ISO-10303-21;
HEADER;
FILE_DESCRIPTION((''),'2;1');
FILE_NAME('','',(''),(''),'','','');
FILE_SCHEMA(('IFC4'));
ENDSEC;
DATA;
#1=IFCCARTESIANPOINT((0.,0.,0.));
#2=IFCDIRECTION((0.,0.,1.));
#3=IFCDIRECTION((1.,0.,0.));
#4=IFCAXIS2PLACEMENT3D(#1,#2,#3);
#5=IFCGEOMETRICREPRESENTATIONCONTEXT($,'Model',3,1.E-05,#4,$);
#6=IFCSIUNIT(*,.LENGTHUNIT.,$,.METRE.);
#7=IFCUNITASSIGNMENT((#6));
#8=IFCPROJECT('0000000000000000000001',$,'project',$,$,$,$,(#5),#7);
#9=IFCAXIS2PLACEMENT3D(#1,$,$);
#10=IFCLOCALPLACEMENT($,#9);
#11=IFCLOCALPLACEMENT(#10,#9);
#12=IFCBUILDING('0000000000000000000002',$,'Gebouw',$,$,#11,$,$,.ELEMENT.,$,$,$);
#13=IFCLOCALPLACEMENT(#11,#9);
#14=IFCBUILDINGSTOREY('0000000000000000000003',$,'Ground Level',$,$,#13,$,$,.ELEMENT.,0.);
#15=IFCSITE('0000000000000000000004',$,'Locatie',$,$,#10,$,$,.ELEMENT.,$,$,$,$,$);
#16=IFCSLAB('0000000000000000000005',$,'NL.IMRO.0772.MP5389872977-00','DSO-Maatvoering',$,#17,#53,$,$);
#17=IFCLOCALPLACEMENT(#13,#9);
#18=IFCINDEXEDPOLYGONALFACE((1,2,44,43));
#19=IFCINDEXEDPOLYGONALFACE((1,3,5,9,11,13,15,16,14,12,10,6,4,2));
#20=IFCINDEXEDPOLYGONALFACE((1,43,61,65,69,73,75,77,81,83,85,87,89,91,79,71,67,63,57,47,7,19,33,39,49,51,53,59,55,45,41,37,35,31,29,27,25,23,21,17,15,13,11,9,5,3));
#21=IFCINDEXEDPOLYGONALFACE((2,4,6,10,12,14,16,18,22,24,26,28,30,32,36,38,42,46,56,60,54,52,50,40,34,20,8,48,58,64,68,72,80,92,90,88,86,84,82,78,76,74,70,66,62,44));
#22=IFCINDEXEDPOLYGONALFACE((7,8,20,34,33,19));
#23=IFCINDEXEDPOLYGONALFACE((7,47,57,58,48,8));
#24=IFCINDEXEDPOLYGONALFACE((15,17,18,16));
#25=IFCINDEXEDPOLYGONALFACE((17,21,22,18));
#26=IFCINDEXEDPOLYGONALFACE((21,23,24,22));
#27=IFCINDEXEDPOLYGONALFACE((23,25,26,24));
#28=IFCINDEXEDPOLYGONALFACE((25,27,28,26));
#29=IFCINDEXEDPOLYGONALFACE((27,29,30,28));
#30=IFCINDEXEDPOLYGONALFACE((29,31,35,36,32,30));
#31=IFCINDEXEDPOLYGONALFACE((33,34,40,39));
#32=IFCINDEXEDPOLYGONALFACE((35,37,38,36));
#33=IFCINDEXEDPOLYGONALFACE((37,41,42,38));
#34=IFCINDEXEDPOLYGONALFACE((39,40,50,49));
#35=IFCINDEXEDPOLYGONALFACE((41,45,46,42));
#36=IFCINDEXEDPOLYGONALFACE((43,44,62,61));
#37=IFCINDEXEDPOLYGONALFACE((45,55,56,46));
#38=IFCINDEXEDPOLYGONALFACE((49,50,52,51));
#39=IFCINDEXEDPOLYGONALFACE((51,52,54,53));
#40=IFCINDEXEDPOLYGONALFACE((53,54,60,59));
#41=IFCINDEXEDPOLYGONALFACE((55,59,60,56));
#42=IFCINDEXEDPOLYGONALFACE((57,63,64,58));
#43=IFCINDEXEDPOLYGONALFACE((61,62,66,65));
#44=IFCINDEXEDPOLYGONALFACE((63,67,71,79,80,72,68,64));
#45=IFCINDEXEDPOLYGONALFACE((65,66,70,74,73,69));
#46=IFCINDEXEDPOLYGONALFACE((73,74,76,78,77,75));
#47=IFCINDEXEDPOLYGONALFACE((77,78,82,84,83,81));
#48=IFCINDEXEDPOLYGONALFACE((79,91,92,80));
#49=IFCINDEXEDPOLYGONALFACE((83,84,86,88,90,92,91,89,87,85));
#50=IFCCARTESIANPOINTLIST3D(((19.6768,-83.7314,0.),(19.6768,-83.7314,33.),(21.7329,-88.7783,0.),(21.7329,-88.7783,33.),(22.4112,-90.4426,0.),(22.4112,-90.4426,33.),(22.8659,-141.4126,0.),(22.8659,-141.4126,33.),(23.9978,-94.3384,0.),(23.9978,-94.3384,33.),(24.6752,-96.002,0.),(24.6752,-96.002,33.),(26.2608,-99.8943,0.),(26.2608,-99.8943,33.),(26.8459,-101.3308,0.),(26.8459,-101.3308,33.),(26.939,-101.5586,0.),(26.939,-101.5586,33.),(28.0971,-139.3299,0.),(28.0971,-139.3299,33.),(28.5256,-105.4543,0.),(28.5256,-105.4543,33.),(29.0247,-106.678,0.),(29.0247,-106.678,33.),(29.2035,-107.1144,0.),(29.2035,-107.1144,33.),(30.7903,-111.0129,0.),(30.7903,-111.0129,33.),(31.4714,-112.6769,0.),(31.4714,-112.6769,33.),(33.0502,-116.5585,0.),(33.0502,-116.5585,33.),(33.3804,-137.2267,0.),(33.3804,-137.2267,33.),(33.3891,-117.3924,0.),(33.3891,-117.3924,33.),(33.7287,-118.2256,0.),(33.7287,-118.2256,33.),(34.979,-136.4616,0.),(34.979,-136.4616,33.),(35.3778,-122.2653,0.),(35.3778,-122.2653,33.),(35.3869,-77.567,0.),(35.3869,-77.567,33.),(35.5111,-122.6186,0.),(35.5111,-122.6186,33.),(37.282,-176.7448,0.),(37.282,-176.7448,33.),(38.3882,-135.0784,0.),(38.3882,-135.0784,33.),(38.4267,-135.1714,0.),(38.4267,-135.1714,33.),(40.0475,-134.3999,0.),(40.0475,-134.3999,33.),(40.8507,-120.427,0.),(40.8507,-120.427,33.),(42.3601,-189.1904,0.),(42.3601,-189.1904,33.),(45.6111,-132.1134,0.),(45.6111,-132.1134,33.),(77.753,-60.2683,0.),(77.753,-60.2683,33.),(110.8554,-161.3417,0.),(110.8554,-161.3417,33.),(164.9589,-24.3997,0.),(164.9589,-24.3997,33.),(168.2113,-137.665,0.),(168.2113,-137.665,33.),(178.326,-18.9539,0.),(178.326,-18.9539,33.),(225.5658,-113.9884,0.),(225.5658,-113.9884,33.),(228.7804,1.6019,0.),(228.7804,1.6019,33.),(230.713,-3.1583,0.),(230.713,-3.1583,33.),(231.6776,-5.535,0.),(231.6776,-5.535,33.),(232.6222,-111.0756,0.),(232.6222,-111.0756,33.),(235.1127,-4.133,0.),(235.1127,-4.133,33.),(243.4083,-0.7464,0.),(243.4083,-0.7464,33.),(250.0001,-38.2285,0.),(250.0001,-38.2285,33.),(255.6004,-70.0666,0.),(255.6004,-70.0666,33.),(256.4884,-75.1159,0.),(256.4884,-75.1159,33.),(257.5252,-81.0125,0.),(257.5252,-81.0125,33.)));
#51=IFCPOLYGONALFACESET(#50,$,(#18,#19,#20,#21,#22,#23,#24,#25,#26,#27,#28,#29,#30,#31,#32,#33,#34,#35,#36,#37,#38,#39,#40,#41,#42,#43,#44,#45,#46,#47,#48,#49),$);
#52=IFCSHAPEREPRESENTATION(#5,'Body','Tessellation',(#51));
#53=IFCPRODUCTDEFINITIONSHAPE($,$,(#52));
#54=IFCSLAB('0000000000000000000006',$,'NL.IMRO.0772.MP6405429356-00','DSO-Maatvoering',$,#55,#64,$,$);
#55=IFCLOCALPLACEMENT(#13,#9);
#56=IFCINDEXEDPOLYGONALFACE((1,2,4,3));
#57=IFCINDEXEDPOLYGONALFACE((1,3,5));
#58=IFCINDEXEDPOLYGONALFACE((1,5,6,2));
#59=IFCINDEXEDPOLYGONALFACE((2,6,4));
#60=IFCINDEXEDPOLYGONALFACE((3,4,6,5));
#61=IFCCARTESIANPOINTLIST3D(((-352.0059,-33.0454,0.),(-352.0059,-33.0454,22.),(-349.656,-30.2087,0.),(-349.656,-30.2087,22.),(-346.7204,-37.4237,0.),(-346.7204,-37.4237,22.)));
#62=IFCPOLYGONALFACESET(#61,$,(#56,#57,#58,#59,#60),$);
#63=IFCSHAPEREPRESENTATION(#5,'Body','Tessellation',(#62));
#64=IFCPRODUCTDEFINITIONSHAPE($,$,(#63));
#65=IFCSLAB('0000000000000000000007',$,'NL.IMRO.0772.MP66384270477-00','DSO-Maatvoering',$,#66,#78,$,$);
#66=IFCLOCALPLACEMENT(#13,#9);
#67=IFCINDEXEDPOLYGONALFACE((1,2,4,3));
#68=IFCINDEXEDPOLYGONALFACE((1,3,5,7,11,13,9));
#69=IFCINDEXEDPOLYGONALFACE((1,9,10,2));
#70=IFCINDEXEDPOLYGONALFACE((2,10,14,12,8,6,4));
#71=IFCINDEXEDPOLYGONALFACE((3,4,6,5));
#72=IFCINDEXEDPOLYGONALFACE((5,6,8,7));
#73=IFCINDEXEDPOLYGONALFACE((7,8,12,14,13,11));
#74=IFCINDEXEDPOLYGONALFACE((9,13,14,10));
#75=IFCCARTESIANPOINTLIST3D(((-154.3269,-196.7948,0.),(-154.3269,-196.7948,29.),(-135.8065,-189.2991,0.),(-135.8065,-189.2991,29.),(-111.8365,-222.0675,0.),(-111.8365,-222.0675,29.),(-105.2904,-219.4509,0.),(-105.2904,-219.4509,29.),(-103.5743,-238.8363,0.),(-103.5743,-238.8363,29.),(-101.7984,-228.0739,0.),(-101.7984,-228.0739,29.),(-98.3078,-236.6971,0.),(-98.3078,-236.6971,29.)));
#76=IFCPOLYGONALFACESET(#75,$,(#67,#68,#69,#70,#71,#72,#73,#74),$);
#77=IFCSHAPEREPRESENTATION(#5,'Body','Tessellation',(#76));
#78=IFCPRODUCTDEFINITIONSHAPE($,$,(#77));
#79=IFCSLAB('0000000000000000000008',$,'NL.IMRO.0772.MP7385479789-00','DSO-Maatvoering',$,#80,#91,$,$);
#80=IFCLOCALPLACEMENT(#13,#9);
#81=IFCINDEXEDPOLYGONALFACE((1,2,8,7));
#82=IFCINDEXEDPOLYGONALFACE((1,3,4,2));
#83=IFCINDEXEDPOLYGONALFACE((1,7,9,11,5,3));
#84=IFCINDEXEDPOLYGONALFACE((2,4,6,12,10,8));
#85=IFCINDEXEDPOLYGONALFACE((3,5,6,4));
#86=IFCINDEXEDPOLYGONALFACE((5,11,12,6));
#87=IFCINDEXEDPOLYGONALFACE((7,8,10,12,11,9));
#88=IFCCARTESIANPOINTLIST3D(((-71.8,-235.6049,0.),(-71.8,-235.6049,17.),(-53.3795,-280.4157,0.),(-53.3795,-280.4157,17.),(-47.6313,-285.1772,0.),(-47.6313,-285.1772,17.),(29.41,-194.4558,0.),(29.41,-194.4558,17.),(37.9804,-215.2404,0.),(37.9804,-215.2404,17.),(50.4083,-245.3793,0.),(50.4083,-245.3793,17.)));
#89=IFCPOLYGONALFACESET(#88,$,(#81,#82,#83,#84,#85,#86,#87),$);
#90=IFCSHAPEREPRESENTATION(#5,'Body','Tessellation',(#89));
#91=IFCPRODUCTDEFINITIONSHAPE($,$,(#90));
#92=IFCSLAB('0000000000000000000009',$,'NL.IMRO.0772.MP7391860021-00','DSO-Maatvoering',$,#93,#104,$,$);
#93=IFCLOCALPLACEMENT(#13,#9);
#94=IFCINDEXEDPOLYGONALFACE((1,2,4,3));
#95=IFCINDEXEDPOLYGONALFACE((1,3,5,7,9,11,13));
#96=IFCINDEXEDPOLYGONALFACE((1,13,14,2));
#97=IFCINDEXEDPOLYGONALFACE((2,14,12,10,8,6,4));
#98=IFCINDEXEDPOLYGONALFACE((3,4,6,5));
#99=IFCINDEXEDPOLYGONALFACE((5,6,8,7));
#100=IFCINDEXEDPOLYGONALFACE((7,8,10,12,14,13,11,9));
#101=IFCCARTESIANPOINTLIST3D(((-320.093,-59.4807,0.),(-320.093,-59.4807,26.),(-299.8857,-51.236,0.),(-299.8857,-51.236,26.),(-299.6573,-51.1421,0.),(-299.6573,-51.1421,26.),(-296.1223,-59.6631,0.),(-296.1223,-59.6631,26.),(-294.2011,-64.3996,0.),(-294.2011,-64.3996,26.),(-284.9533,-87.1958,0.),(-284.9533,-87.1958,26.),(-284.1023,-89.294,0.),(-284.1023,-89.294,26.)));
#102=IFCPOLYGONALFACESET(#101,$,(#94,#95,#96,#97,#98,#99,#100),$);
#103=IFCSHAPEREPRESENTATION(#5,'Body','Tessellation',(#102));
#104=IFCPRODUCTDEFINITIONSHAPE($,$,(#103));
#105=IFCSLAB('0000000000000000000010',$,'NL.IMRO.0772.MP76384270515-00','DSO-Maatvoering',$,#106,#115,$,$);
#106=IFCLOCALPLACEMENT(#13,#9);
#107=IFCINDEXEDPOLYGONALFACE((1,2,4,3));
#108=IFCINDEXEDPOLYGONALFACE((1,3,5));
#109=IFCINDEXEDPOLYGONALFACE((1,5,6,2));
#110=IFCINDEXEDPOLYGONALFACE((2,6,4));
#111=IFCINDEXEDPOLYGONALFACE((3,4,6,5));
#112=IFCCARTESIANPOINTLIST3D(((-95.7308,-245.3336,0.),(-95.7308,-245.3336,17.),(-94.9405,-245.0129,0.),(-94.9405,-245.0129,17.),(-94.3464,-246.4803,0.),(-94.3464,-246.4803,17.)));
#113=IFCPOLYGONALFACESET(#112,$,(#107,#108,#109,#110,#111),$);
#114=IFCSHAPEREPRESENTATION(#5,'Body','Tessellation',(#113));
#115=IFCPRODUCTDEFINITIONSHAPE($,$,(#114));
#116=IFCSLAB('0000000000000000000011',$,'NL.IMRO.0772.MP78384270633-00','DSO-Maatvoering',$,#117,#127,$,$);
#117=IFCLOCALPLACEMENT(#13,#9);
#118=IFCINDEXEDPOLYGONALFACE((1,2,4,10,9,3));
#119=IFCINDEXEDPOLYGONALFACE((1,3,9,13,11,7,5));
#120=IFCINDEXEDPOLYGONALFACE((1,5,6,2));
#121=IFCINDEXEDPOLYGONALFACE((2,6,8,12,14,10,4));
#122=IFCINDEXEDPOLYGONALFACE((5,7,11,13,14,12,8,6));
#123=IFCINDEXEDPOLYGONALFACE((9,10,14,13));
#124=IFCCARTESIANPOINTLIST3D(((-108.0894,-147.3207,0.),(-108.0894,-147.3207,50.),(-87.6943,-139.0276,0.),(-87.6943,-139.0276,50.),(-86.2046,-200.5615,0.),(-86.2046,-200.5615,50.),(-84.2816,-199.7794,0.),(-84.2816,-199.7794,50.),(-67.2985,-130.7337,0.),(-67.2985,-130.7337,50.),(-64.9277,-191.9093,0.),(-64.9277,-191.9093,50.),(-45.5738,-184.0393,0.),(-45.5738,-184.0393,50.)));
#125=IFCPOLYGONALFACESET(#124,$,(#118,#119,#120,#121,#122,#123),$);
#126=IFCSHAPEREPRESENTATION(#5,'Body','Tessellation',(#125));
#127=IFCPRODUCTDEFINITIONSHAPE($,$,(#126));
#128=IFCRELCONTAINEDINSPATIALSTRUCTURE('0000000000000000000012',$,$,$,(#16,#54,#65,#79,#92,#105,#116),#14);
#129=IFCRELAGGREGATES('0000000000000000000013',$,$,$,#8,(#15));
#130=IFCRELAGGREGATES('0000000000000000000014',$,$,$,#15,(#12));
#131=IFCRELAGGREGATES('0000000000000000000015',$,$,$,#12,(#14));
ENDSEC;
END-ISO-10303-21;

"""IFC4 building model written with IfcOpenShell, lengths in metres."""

from ifc_helpers import new_model, si_unit, origin, origin_with_axes, place, context, project, spatial, polyline, outline, extrude, element, save


model = new_model("IFC4")

# Units and contexts
model_context = context("Model", 3, precision=1e-05, world=origin_with_axes())
ifc_project = project(units=[si_unit("LENGTHUNIT", "METRE")], contexts=[model_context])

# Site, building, storey
site_placement = place(None, origin())
site = spatial("IfcSite", under=ifc_project, at=site_placement, Name="Locatie", CompositionType="ELEMENT")
building_placement = place(site_placement, origin())
building = spatial("IfcBuilding", under=site, at=building_placement, Name="Gebouw", CompositionType="ELEMENT")
storey_placement = place(building_placement, origin())
storey = spatial("IfcBuildingStorey", under=building, at=storey_placement, Name="Ground Level", CompositionType="ELEMENT", Elevation=0.0)

# Slabs
slab_1_placement = place(storey_placement, origin())
element("IfcSlab", 1, at=slab_1_placement, inside=storey, Name="NL.IMRO.0772.MP5389872977-00", Description="DSO-Maatvoering", context=model_context, shape_type="SweptSolid", body=[
    extrude(outline(polyline([(225.5658, -113.9884), (168.2113, -137.665), (110.8554, -161.3417), (42.3601, -189.1904), (37.282, -176.7448), (22.8659, -141.4126), (28.0971, -139.3299), (33.3804, -137.2267), (34.979, -136.4616), (38.3882, -135.0784), (38.4267, -135.1714), (40.0475, -134.3999), (45.6111, -132.1134), (40.8507, -120.427), (35.5111, -122.6186), (35.3778, -122.2653), (33.7287, -118.2256), (33.3891, -117.3924), (33.0502, -116.5585), (31.4714, -112.6769), (30.7903, -111.0129), (29.2035, -107.1144), (29.0247, -106.678), (28.5256, -105.4543), (26.939, -101.5586), (26.8459, -101.3308), (26.2608, -99.8943), (24.6752, -96.002), (23.9978, -94.3384), (22.4112, -90.4426), (21.7329, -88.7783), (19.6768, -83.7314), (35.3869, -77.567), (77.753, -60.2683), (164.9589, -24.3997), (178.326, -18.9539), (228.7804, 1.6019), (230.713, -3.1583), (231.6776, -5.535), (235.1127, -4.133), (243.4083, -0.7464), (250.0001, -38.2285), (255.6004, -70.0666), (256.4884, -75.1159), (257.5252, -81.0125), (232.6222, -111.0756), (225.5658, -113.9884)])), origin_with_axes(), (0.0, 0.0, 1.0), 33.0),
])
slab_2_placement = place(storey_placement, origin())
element("IfcSlab", 2, at=slab_2_placement, inside=storey, Name="NL.IMRO.0772.MP6405429356-00", Description="DSO-Maatvoering", context=model_context, shape_type="SweptSolid", body=[
    extrude(outline(polyline([(-346.7204, -37.4237), (-352.0059, -33.0454), (-349.656, -30.2087), (-346.7204, -37.4237)])), origin_with_axes(), (0.0, 0.0, 1.0), 22.0),
])
slab_3_placement = place(storey_placement, origin())
element("IfcSlab", 3, at=slab_3_placement, inside=storey, Name="NL.IMRO.0772.MP66384270477-00", Description="DSO-Maatvoering", context=model_context, shape_type="SweptSolid", body=[
    extrude(outline(polyline([(-135.8065, -189.2991), (-111.8365, -222.0675), (-105.2904, -219.4509), (-101.7984, -228.0739), (-98.3078, -236.6971), (-103.5743, -238.8363), (-154.3269, -196.7948), (-135.8065, -189.2991)])), origin_with_axes(), (0.0, 0.0, 1.0), 29.0),
])
slab_4_placement = place(storey_placement, origin())
element("IfcSlab", 4, at=slab_4_placement, inside=storey, Name="NL.IMRO.0772.MP7385479789-00", Description="DSO-Maatvoering", context=model_context, shape_type="SweptSolid", body=[
    extrude(outline(polyline([(-71.8, -235.6049), (29.41, -194.4558), (37.9804, -215.2404), (50.4083, -245.3793), (-47.6313, -285.1772), (-53.3795, -280.4157), (-71.8, -235.6049)])), origin_with_axes(), (0.0, 0.0, 1.0), 17.0),
])
slab_5_placement = place(storey_placement, origin())
element("IfcSlab", 5, at=slab_5_placement, inside=storey, Name="NL.IMRO.0772.MP7391860021-00", Description="DSO-Maatvoering", context=model_context, shape_type="SweptSolid", body=[
    extrude(outline(polyline([(-299.8857, -51.236), (-299.6573, -51.1421), (-296.1223, -59.6631), (-294.2011, -64.3996), (-284.9533, -87.1958), (-284.1023, -89.294), (-320.093, -59.4807), (-299.8857, -51.236)])), origin_with_axes(), (0.0, 0.0, 1.0), 26.0),
])
slab_6_placement = place(storey_placement, origin())
element("IfcSlab", 6, at=slab_6_placement, inside=storey, Name="NL.IMRO.0772.MP76384270515-00", Description="DSO-Maatvoering", context=model_context, shape_type="SweptSolid", body=[
    extrude(outline(polyline([(-94.9405, -245.0129), (-94.3464, -246.4803), (-95.7308, -245.3336), (-94.9405, -245.0129)])), origin_with_axes(), (0.0, 0.0, 1.0), 17.0),
])
slab_7_placement = place(storey_placement, origin())
element("IfcSlab", 7, at=slab_7_placement, inside=storey, Name="NL.IMRO.0772.MP78384270633-00", Description="DSO-Maatvoering", context=model_context, shape_type="SweptSolid", body=[
    extrude(outline(polyline([(-87.6943, -139.0276), (-67.2985, -130.7337), (-45.5738, -184.0393), (-64.9277, -191.9093), (-84.2816, -199.7794), (-86.2046, -200.5615), (-108.0894, -147.3207), (-87.6943, -139.0276)])), origin_with_axes(), (0.0, 0.0, 1.0), 50.0),
])

save(model, "model.ifc")
